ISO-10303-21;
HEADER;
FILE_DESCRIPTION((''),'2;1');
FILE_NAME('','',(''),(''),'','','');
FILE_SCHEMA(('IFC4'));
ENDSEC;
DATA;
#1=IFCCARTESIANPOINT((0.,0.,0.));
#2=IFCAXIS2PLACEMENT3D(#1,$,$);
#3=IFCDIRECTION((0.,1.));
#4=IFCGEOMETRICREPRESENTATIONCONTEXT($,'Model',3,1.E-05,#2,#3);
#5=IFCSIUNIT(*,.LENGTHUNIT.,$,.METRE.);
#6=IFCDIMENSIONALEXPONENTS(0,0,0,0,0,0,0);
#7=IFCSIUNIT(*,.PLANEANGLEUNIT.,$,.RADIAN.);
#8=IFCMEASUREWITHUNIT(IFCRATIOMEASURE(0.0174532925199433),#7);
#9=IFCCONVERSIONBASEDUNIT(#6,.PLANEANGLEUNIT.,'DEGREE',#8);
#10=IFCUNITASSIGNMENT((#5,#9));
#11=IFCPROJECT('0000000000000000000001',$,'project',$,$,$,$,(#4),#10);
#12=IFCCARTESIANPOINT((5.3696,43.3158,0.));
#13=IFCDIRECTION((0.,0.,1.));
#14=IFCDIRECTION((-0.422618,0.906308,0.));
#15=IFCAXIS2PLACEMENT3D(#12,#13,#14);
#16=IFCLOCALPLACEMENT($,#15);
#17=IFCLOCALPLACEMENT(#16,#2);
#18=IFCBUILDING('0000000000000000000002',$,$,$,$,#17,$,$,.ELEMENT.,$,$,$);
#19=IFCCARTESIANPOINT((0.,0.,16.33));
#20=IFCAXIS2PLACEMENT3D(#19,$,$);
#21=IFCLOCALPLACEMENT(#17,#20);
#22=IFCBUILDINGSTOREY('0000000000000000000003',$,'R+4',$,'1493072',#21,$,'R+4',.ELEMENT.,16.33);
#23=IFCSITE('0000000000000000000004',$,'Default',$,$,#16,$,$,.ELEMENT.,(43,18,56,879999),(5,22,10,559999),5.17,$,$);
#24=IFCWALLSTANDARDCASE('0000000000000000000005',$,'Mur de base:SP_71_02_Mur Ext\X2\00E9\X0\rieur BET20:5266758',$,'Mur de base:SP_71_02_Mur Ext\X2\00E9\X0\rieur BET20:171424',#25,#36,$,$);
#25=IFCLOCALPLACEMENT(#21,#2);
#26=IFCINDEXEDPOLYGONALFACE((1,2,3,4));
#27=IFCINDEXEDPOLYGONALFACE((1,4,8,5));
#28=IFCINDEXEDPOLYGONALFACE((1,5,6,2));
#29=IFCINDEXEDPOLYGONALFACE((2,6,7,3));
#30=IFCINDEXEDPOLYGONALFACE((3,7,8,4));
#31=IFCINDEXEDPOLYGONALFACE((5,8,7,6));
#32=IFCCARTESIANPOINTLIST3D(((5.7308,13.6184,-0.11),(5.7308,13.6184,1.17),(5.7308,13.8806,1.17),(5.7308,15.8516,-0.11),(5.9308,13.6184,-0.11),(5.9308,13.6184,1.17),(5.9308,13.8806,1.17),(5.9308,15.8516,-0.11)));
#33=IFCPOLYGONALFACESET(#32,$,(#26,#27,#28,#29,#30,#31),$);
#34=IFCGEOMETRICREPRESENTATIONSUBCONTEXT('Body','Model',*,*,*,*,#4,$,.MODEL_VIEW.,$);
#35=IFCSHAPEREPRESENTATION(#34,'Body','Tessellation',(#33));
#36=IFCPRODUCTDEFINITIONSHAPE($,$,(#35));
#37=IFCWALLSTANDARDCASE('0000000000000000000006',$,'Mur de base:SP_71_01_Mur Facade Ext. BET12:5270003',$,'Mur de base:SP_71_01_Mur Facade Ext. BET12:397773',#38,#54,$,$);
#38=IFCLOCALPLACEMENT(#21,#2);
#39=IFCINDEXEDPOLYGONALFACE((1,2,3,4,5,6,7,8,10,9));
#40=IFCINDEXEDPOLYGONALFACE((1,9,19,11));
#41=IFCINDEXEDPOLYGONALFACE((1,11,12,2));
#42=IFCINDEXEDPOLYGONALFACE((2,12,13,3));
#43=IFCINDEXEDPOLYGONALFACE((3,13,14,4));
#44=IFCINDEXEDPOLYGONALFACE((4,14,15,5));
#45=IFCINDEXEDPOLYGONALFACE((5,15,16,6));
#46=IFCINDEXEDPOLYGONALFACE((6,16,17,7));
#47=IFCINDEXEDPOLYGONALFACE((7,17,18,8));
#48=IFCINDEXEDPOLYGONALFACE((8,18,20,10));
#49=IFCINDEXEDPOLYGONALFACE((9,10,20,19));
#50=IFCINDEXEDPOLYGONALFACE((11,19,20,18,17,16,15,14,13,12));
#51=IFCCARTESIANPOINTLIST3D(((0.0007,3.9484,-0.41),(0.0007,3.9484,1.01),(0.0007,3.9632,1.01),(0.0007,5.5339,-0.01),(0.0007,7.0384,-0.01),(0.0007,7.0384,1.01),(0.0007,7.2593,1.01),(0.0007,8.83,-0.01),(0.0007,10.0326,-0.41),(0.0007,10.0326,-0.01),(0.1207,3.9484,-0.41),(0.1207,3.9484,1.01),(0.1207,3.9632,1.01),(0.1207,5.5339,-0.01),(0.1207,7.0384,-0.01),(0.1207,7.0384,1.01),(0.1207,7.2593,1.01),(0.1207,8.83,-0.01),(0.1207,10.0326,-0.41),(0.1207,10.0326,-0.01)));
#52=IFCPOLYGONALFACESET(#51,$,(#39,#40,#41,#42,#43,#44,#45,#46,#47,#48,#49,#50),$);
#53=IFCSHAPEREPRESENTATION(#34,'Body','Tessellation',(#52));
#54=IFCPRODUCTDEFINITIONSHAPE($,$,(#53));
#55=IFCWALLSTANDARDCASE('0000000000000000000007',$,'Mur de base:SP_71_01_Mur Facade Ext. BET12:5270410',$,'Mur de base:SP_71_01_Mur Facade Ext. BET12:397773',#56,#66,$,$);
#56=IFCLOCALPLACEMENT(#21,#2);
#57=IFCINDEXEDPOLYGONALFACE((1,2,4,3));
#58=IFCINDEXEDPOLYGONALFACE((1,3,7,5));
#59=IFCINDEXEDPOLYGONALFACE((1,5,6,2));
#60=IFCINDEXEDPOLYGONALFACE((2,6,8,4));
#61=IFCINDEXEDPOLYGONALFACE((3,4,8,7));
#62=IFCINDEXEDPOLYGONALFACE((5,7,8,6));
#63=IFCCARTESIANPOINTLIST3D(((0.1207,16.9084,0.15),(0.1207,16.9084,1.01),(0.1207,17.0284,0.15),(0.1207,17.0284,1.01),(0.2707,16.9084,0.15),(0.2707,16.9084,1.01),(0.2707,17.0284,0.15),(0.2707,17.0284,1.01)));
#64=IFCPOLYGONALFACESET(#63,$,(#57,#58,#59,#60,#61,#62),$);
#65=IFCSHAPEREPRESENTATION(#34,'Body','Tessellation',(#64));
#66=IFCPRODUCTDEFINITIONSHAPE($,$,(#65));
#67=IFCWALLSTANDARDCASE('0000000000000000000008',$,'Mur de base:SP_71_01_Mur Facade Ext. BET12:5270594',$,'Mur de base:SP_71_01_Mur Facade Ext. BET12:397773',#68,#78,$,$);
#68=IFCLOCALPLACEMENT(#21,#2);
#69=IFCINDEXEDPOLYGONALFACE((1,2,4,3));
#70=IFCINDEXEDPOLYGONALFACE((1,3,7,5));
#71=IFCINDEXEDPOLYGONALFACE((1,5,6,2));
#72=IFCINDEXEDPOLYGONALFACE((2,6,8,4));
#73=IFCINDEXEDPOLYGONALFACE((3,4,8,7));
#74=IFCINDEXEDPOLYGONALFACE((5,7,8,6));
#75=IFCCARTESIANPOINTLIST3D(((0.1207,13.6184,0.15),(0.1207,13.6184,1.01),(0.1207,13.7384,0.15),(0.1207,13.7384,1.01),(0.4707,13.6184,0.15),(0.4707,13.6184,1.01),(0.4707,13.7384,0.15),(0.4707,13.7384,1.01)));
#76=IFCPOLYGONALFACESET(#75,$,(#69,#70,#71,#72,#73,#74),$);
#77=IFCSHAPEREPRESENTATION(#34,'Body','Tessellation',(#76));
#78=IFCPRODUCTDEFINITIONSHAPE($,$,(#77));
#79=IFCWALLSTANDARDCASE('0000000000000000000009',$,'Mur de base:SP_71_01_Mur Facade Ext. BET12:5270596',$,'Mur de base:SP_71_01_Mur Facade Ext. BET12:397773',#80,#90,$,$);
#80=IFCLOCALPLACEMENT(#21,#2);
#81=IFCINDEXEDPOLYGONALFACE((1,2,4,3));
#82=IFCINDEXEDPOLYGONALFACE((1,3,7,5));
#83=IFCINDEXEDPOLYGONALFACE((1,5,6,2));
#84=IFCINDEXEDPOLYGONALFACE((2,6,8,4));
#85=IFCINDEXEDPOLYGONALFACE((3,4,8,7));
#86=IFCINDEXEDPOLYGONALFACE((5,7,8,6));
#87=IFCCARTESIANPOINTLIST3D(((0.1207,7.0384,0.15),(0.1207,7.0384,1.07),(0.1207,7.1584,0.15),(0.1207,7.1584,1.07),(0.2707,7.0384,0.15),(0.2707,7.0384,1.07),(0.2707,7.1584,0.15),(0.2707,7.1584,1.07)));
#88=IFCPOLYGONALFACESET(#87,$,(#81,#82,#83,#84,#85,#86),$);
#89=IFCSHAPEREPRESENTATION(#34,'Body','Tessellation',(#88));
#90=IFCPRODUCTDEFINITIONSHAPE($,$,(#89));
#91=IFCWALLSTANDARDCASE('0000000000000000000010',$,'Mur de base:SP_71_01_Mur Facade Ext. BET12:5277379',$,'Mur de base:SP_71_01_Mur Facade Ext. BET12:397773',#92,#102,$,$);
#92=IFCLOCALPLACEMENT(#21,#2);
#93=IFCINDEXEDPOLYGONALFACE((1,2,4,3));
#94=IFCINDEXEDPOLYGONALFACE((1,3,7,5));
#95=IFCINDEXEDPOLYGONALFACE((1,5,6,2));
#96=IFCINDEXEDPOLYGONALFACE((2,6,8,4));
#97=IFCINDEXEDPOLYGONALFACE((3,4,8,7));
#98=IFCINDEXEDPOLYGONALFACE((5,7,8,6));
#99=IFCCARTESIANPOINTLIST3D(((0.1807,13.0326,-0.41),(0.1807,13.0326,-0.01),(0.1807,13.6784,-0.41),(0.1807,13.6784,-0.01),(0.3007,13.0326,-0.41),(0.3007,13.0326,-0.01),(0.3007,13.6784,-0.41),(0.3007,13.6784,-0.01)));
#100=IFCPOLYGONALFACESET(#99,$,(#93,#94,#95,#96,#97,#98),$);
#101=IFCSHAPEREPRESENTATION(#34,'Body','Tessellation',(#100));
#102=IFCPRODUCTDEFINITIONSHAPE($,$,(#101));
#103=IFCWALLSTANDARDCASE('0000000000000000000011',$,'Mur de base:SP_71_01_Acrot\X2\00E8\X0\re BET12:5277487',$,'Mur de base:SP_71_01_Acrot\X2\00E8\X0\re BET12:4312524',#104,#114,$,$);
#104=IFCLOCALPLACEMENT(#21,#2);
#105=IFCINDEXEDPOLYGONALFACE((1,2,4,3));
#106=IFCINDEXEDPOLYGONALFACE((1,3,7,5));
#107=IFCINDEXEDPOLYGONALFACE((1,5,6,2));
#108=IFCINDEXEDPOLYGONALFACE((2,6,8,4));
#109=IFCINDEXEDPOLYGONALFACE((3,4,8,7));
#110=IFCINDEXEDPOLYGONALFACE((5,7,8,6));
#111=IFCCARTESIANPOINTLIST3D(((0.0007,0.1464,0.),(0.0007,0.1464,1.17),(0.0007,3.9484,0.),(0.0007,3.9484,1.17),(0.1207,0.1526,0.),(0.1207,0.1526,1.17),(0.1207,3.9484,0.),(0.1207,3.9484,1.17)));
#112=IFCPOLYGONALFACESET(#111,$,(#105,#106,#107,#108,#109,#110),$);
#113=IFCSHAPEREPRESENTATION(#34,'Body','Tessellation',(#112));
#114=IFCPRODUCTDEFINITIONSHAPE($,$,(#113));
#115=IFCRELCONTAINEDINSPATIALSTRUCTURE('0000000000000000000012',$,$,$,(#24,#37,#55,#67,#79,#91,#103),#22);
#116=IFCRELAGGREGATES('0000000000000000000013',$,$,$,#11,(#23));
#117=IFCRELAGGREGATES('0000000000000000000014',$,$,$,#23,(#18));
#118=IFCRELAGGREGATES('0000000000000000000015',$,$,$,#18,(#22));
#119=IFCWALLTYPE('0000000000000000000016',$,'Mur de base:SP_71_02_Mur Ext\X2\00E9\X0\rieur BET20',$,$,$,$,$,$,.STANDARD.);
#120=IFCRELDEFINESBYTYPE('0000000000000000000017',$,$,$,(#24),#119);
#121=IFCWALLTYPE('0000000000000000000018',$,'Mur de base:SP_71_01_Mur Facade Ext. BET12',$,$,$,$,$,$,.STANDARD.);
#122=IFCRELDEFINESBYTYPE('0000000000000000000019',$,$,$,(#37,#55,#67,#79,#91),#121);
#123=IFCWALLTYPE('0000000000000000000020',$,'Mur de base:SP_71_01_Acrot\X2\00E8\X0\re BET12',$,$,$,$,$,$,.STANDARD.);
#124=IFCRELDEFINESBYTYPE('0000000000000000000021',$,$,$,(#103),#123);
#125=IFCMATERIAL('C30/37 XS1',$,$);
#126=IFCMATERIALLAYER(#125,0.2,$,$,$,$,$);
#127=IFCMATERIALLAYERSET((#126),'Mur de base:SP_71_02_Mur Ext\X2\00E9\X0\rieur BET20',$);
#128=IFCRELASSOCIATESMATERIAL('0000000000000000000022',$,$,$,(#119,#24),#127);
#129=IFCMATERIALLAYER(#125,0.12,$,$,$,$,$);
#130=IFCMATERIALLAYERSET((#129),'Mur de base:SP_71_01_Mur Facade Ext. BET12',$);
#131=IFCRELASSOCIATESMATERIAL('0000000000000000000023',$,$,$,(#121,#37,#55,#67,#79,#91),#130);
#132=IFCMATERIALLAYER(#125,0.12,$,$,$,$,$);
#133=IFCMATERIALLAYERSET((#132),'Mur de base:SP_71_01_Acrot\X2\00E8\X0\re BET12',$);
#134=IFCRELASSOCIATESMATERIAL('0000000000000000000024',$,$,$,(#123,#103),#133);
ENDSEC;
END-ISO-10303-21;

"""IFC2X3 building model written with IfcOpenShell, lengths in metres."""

from ifc_helpers import new_model, entity, si_unit, converted_unit, direction, frame, frame_2d, origin, place, context, subcontext, project, spatial, polyline, rectangle, outline, extrude, clip, halfspace, bounded_halfspace, material, layer, layer_set, layer_usage, type_object, element, save


model = new_model("IFC2X3")

# Units and contexts
model_context = context("Model", 3, precision=1e-05, world=origin(), true_north=direction((0.0, 1.0)))
body_context = subcontext(model_context, "Body", "Model", "MODEL_VIEW")
ifc_project = project(units=[si_unit("LENGTHUNIT", "METRE"), converted_unit("PLANEANGLEUNIT", "DEGREE", entity("IfcRatioMeasure", 0.0174532925199433), si_unit("PLANEANGLEUNIT", "RADIAN"), dimensions=[0, 0, 0, 0, 0, 0, 0])], contexts=[model_context])

# Site, building, storey
site_placement = place(None, frame((5.3696, 43.3158, 0.0), z_axis=(0.0, 0.0, 1.0), x_axis=(-0.422618, 0.906308, 0.0)))
site = spatial("IfcSite", under=ifc_project, at=site_placement, Name="Default", CompositionType="ELEMENT", RefLatitude=(43, 18, 56, 879999), RefLongitude=(5, 22, 10, 559999), RefElevation=5.17)
building_placement = place(site_placement, origin())
building = spatial("IfcBuilding", under=site, at=building_placement, CompositionType="ELEMENT")
storey_placement = place(building_placement, frame((0.0, 0.0, 16.33)))
storey = spatial("IfcBuildingStorey", under=building, at=storey_placement, Name="R+4", ObjectType="1493072", LongName="R+4", CompositionType="ELEMENT", Elevation=16.33)

# Shared definitions
ifc_material_1 = material(Name="C30/37 XS1")

# Walls
ifc_layer_1 = layer(ifc_material_1, 0.2)
ifc_layer_set_1 = layer_set([ifc_layer_1], Name="Mur de base:SP_71_02_Mur Extérieur BET20")
ifc_layer_usage_1 = layer_usage(ifc_layer_set_1, "AXIS2", "NEGATIVE", 0.1)
wall_type_1 = type_object("IfcWallType", Name="Mur de base:SP_71_02_Mur Extérieur BET20", PredefinedType="STANDARD", material=ifc_layer_set_1)
wall_1_placement = place(storey_placement, frame((5.8308, 15.8516, -0.11), z_axis=(0.0, 0.0, 1.0), x_axis=(0.0, -1.0, 0.0)))
element("IfcWallStandardCase", 1, at=wall_1_placement, inside=storey, type_object=wall_type_1, material=ifc_layer_usage_1, Name="Mur de base:SP_71_02_Mur Extérieur BET20:5266758", ObjectType="Mur de base:SP_71_02_Mur Extérieur BET20:171424", context=body_context, shape_type="Clipping", body=[
    clip(clip(clip(extrude(rectangle(XDim=2.2332, YDim=0.2, at=frame_2d((1.1166, 0.0), x_axis=(-1.0, 0.0))), origin(), (0.0, 0.0, 1.0), 1.28), bounded_halfspace(frame((2.2332, -0.1, 0.0)), True, frame((2.2332, -0.1, 0.0)), polyline([(0.0, 0.0), (0.0, 0.2), (-2.2332, 0.2), (-2.2332, 0.0), (0.0, 0.0)]))), halfspace(frame((1.971, -0.1, 1.28), z_axis=(0.0, 0.0, 1.0), x_axis=(0.0, 1.0, 0.0)), False)), halfspace(frame((0.0, -0.1, 0.0), z_axis=(-0.544639, 0.0, 0.838671), x_axis=(0.0, 1.0, 0.0)), False)),
])
ifc_layer_2 = layer(ifc_material_1, 0.12)
ifc_layer_set_2 = layer_set([ifc_layer_2], Name="Mur de base:SP_71_01_Mur Facade Ext. BET12")
ifc_layer_usage_2 = layer_usage(ifc_layer_set_2, "AXIS2", "NEGATIVE", 0.06)
wall_type_2 = type_object("IfcWallType", Name="Mur de base:SP_71_01_Mur Facade Ext. BET12", PredefinedType="STANDARD", material=ifc_layer_set_2)
wall_2_placement = place(storey_placement, frame((0.0607, 10.0926, -0.41), z_axis=(0.0, 0.0, 1.0), x_axis=(0.0, -1.0, 0.0)))
element("IfcWallStandardCase", 2, at=wall_2_placement, inside=storey, type_object=wall_type_2, material=ifc_layer_usage_2, Name="Mur de base:SP_71_01_Mur Facade Ext. BET12:5270003", ObjectType="Mur de base:SP_71_01_Mur Facade Ext. BET12:397773", context=body_context, shape_type="Clipping", body=[
    clip(clip(clip(clip(clip(clip(extrude(rectangle(XDim=6.0842, YDim=0.12, at=frame_2d((3.1021, 0.0), x_axis=(-1.0, 0.0))), origin(), (0.0, 0.0, 1.0), 1.42), bounded_halfspace(frame((2.8333, -0.06, 1.42), z_axis=(0.0, 0.0, -1.0), x_axis=(0.0, -1.0, 0.0)), True, frame((2.8333, -0.06, 1.42)), polyline([(0.0, 0.0), (0.2209, 0.0), (0.2209, 0.12), (0.0, 0.12), (0.0, 0.0)]))), bounded_halfspace(frame((6.1294, -0.06, 1.42), z_axis=(0.0, 0.0, -1.0), x_axis=(0.0, -1.0, 0.0)), True, frame((6.1294, -0.06, 1.42)), polyline([(0.0, 0.0), (0.0148, 0.0), (0.0148, 0.12), (0.0, 0.12), (0.0, 0.0)]))), bounded_halfspace(frame((1.2626, -0.06, 0.4), z_axis=(0.544639, 0.0, -0.838671), x_axis=(0.0, -1.0, 0.0)), True, frame((1.2626, -0.06, 0.4)), polyline([(0.0, 0.0), (1.5707, 0.0), (1.5707, 0.12), (0.0, 0.12), (0.0, 0.0)]))), bounded_halfspace(frame((4.5587, -0.06, 0.4), z_axis=(0.544639, 0.0, -0.838671), x_axis=(0.0, -1.0, 0.0)), True, frame((4.5587, -0.06, 0.4)), polyline([(0.0, 0.0), (1.5707, 0.0), (1.5707, 0.12), (0.0, 0.12), (0.0, 0.0)]))), bounded_halfspace(frame((0.0, -0.06, 0.4), z_axis=(0.0, 0.0, -1.0), x_axis=(0.0, -1.0, 0.0)), True, frame((0.0, -0.06, 0.4)), polyline([(0.0, 0.0), (1.2626, 0.0), (1.2626, 0.12), (0.0, 0.12), (0.0, 0.0)]))), bounded_halfspace(frame((3.0542, -0.06, 0.4), z_axis=(0.0, 0.0, -1.0), x_axis=(0.0, -1.0, 0.0)), True, frame((3.0542, -0.06, 0.4)), polyline([(0.0, 0.0), (1.5045, 0.0), (1.5045, 0.12), (0.0, 0.12), (0.0, 0.0)]))),
])
ifc_layer_usage_3 = layer_usage(ifc_layer_set_2, "AXIS2", "NEGATIVE", 0.06)
wall_3_placement = place(storey_placement, frame((0.1207, 16.9684, 0.15)))
element("IfcWallStandardCase", 3, at=wall_3_placement, inside=storey, type_object=wall_type_2, material=ifc_layer_usage_3, Name="Mur de base:SP_71_01_Mur Facade Ext. BET12:5270410", ObjectType="Mur de base:SP_71_01_Mur Facade Ext. BET12:397773", context=body_context, shape_type="Clipping", body=[
    clip(extrude(rectangle(XDim=0.15, YDim=0.12, at=frame_2d((0.075, 0.0), x_axis=(-1.0, 0.0))), origin(), (0.0, 0.0, 1.0), 0.86), bounded_halfspace(frame((0.0, -0.06, 0.86), z_axis=(0.0, 0.0, -1.0), x_axis=(-1.0, 0.0, 0.0)), True, frame((0.0, -0.06, 0.86), z_axis=(0.0, 0.0, -1.0), x_axis=(-1.0, 0.0, 0.0)), polyline([(0.0, 0.0), (0.0, 0.12), (-0.15, 0.12), (-0.15, 0.0), (0.0, 0.0)]))),
])
ifc_layer_usage_4 = layer_usage(ifc_layer_set_2, "AXIS2", "NEGATIVE", 0.06)
wall_4_placement = place(storey_placement, frame((0.1207, 13.6784, 0.15)))
element("IfcWallStandardCase", 4, at=wall_4_placement, inside=storey, type_object=wall_type_2, material=ifc_layer_usage_4, Name="Mur de base:SP_71_01_Mur Facade Ext. BET12:5270594", ObjectType="Mur de base:SP_71_01_Mur Facade Ext. BET12:397773", context=body_context, shape_type="Clipping", body=[
    clip(extrude(rectangle(XDim=0.35, YDim=0.12, at=frame_2d((0.175, 0.0), x_axis=(-1.0, 0.0))), origin(), (0.0, 0.0, 1.0), 0.86), bounded_halfspace(frame((0.0, -0.06, 0.86), z_axis=(0.0, 0.0, -1.0), x_axis=(-1.0, 0.0, 0.0)), True, frame((0.0, -0.06, 0.86), z_axis=(0.0, 0.0, -1.0), x_axis=(-1.0, 0.0, 0.0)), polyline([(0.0, 0.0), (0.0, 0.12), (-0.15, 0.12), (-0.35, 0.12), (-0.35, 0.0), (0.0, 0.0)]))),
])
ifc_layer_usage_5 = layer_usage(ifc_layer_set_2, "AXIS2", "NEGATIVE", 0.06)
wall_5_placement = place(storey_placement, frame((0.2707, 7.0984, 0.15), z_axis=(0.0, 0.0, 1.0), x_axis=(-1.0, 0.0, 0.0)))
element("IfcWallStandardCase", 5, at=wall_5_placement, inside=storey, type_object=wall_type_2, material=ifc_layer_usage_5, Name="Mur de base:SP_71_01_Mur Facade Ext. BET12:5270596", ObjectType="Mur de base:SP_71_01_Mur Facade Ext. BET12:397773", context=body_context, shape_type="SweptSolid", body=[
    extrude(rectangle(XDim=0.15, YDim=0.12, at=frame_2d((0.075, 0.0), x_axis=(-1.0, 0.0))), origin(), (0.0, 0.0, 1.0), 0.92),
])
ifc_layer_usage_6 = layer_usage(ifc_layer_set_2, "AXIS2", "NEGATIVE", 0.06)
wall_6_placement = place(storey_placement, frame((0.2407, 13.6784, -0.41), z_axis=(0.0, 0.0, 1.0), x_axis=(0.0, -1.0, 0.0)))
element("IfcWallStandardCase", 6, at=wall_6_placement, inside=storey, type_object=wall_type_2, material=ifc_layer_usage_6, Name="Mur de base:SP_71_01_Mur Facade Ext. BET12:5277379", ObjectType="Mur de base:SP_71_01_Mur Facade Ext. BET12:397773", context=body_context, shape_type="Clipping", body=[
    clip(extrude(rectangle(XDim=0.6458, YDim=0.12, at=frame_2d((0.3229, 0.0), x_axis=(-1.0, 0.0))), origin(), (0.0, 0.0, 1.0), 0.4), bounded_halfspace(frame((0.0, -0.06, 0.4), z_axis=(0.0, 0.0, 1.0), x_axis=(0.0, 1.0, 0.0)), False, frame((0.0, -0.06, 0.4)), polyline([(0.0, 0.0), (0.6458, 0.0), (0.6458, 0.12), (0.06, 0.12), (0.0, 0.12), (0.0, 0.09), (0.0, 0.0)]))),
])
ifc_layer_3 = layer(ifc_material_1, 0.12)
ifc_layer_set_3 = layer_set([ifc_layer_3], Name="Mur de base:SP_71_01_Acrotère BET12")
wall_type_3 = type_object("IfcWallType", Name="Mur de base:SP_71_01_Acrotère BET12", PredefinedType="STANDARD", material=ifc_layer_set_3)
ifc_layer_usage_7 = layer_usage(ifc_layer_set_3, "AXIS2", "NEGATIVE", 0.06)
wall_7_placement = place(storey_placement, frame((0.0607, 3.9484, 0.0), z_axis=(0.0, 0.0, 1.0), x_axis=(0.0, -1.0, 0.0)))
element("IfcWallStandardCase", 7, at=wall_7_placement, inside=storey, type_object=wall_type_3, material=ifc_layer_usage_7, Name="Mur de base:SP_71_01_Acrotère BET12:5277487", ObjectType="Mur de base:SP_71_01_Acrotère BET12:4312524", context=body_context, shape_type="Clipping", body=[
    clip(extrude(outline(polyline([(3.802, -0.06), (3.7958, 0.06), (0.0, 0.06), (0.0, -0.06), (3.802, -0.06)])), origin(), (0.0, 0.0, 1.0), 1.17), halfspace(frame((0.0, 0.0, -3.53)), True)),
])

save(model, "model.ifc")
